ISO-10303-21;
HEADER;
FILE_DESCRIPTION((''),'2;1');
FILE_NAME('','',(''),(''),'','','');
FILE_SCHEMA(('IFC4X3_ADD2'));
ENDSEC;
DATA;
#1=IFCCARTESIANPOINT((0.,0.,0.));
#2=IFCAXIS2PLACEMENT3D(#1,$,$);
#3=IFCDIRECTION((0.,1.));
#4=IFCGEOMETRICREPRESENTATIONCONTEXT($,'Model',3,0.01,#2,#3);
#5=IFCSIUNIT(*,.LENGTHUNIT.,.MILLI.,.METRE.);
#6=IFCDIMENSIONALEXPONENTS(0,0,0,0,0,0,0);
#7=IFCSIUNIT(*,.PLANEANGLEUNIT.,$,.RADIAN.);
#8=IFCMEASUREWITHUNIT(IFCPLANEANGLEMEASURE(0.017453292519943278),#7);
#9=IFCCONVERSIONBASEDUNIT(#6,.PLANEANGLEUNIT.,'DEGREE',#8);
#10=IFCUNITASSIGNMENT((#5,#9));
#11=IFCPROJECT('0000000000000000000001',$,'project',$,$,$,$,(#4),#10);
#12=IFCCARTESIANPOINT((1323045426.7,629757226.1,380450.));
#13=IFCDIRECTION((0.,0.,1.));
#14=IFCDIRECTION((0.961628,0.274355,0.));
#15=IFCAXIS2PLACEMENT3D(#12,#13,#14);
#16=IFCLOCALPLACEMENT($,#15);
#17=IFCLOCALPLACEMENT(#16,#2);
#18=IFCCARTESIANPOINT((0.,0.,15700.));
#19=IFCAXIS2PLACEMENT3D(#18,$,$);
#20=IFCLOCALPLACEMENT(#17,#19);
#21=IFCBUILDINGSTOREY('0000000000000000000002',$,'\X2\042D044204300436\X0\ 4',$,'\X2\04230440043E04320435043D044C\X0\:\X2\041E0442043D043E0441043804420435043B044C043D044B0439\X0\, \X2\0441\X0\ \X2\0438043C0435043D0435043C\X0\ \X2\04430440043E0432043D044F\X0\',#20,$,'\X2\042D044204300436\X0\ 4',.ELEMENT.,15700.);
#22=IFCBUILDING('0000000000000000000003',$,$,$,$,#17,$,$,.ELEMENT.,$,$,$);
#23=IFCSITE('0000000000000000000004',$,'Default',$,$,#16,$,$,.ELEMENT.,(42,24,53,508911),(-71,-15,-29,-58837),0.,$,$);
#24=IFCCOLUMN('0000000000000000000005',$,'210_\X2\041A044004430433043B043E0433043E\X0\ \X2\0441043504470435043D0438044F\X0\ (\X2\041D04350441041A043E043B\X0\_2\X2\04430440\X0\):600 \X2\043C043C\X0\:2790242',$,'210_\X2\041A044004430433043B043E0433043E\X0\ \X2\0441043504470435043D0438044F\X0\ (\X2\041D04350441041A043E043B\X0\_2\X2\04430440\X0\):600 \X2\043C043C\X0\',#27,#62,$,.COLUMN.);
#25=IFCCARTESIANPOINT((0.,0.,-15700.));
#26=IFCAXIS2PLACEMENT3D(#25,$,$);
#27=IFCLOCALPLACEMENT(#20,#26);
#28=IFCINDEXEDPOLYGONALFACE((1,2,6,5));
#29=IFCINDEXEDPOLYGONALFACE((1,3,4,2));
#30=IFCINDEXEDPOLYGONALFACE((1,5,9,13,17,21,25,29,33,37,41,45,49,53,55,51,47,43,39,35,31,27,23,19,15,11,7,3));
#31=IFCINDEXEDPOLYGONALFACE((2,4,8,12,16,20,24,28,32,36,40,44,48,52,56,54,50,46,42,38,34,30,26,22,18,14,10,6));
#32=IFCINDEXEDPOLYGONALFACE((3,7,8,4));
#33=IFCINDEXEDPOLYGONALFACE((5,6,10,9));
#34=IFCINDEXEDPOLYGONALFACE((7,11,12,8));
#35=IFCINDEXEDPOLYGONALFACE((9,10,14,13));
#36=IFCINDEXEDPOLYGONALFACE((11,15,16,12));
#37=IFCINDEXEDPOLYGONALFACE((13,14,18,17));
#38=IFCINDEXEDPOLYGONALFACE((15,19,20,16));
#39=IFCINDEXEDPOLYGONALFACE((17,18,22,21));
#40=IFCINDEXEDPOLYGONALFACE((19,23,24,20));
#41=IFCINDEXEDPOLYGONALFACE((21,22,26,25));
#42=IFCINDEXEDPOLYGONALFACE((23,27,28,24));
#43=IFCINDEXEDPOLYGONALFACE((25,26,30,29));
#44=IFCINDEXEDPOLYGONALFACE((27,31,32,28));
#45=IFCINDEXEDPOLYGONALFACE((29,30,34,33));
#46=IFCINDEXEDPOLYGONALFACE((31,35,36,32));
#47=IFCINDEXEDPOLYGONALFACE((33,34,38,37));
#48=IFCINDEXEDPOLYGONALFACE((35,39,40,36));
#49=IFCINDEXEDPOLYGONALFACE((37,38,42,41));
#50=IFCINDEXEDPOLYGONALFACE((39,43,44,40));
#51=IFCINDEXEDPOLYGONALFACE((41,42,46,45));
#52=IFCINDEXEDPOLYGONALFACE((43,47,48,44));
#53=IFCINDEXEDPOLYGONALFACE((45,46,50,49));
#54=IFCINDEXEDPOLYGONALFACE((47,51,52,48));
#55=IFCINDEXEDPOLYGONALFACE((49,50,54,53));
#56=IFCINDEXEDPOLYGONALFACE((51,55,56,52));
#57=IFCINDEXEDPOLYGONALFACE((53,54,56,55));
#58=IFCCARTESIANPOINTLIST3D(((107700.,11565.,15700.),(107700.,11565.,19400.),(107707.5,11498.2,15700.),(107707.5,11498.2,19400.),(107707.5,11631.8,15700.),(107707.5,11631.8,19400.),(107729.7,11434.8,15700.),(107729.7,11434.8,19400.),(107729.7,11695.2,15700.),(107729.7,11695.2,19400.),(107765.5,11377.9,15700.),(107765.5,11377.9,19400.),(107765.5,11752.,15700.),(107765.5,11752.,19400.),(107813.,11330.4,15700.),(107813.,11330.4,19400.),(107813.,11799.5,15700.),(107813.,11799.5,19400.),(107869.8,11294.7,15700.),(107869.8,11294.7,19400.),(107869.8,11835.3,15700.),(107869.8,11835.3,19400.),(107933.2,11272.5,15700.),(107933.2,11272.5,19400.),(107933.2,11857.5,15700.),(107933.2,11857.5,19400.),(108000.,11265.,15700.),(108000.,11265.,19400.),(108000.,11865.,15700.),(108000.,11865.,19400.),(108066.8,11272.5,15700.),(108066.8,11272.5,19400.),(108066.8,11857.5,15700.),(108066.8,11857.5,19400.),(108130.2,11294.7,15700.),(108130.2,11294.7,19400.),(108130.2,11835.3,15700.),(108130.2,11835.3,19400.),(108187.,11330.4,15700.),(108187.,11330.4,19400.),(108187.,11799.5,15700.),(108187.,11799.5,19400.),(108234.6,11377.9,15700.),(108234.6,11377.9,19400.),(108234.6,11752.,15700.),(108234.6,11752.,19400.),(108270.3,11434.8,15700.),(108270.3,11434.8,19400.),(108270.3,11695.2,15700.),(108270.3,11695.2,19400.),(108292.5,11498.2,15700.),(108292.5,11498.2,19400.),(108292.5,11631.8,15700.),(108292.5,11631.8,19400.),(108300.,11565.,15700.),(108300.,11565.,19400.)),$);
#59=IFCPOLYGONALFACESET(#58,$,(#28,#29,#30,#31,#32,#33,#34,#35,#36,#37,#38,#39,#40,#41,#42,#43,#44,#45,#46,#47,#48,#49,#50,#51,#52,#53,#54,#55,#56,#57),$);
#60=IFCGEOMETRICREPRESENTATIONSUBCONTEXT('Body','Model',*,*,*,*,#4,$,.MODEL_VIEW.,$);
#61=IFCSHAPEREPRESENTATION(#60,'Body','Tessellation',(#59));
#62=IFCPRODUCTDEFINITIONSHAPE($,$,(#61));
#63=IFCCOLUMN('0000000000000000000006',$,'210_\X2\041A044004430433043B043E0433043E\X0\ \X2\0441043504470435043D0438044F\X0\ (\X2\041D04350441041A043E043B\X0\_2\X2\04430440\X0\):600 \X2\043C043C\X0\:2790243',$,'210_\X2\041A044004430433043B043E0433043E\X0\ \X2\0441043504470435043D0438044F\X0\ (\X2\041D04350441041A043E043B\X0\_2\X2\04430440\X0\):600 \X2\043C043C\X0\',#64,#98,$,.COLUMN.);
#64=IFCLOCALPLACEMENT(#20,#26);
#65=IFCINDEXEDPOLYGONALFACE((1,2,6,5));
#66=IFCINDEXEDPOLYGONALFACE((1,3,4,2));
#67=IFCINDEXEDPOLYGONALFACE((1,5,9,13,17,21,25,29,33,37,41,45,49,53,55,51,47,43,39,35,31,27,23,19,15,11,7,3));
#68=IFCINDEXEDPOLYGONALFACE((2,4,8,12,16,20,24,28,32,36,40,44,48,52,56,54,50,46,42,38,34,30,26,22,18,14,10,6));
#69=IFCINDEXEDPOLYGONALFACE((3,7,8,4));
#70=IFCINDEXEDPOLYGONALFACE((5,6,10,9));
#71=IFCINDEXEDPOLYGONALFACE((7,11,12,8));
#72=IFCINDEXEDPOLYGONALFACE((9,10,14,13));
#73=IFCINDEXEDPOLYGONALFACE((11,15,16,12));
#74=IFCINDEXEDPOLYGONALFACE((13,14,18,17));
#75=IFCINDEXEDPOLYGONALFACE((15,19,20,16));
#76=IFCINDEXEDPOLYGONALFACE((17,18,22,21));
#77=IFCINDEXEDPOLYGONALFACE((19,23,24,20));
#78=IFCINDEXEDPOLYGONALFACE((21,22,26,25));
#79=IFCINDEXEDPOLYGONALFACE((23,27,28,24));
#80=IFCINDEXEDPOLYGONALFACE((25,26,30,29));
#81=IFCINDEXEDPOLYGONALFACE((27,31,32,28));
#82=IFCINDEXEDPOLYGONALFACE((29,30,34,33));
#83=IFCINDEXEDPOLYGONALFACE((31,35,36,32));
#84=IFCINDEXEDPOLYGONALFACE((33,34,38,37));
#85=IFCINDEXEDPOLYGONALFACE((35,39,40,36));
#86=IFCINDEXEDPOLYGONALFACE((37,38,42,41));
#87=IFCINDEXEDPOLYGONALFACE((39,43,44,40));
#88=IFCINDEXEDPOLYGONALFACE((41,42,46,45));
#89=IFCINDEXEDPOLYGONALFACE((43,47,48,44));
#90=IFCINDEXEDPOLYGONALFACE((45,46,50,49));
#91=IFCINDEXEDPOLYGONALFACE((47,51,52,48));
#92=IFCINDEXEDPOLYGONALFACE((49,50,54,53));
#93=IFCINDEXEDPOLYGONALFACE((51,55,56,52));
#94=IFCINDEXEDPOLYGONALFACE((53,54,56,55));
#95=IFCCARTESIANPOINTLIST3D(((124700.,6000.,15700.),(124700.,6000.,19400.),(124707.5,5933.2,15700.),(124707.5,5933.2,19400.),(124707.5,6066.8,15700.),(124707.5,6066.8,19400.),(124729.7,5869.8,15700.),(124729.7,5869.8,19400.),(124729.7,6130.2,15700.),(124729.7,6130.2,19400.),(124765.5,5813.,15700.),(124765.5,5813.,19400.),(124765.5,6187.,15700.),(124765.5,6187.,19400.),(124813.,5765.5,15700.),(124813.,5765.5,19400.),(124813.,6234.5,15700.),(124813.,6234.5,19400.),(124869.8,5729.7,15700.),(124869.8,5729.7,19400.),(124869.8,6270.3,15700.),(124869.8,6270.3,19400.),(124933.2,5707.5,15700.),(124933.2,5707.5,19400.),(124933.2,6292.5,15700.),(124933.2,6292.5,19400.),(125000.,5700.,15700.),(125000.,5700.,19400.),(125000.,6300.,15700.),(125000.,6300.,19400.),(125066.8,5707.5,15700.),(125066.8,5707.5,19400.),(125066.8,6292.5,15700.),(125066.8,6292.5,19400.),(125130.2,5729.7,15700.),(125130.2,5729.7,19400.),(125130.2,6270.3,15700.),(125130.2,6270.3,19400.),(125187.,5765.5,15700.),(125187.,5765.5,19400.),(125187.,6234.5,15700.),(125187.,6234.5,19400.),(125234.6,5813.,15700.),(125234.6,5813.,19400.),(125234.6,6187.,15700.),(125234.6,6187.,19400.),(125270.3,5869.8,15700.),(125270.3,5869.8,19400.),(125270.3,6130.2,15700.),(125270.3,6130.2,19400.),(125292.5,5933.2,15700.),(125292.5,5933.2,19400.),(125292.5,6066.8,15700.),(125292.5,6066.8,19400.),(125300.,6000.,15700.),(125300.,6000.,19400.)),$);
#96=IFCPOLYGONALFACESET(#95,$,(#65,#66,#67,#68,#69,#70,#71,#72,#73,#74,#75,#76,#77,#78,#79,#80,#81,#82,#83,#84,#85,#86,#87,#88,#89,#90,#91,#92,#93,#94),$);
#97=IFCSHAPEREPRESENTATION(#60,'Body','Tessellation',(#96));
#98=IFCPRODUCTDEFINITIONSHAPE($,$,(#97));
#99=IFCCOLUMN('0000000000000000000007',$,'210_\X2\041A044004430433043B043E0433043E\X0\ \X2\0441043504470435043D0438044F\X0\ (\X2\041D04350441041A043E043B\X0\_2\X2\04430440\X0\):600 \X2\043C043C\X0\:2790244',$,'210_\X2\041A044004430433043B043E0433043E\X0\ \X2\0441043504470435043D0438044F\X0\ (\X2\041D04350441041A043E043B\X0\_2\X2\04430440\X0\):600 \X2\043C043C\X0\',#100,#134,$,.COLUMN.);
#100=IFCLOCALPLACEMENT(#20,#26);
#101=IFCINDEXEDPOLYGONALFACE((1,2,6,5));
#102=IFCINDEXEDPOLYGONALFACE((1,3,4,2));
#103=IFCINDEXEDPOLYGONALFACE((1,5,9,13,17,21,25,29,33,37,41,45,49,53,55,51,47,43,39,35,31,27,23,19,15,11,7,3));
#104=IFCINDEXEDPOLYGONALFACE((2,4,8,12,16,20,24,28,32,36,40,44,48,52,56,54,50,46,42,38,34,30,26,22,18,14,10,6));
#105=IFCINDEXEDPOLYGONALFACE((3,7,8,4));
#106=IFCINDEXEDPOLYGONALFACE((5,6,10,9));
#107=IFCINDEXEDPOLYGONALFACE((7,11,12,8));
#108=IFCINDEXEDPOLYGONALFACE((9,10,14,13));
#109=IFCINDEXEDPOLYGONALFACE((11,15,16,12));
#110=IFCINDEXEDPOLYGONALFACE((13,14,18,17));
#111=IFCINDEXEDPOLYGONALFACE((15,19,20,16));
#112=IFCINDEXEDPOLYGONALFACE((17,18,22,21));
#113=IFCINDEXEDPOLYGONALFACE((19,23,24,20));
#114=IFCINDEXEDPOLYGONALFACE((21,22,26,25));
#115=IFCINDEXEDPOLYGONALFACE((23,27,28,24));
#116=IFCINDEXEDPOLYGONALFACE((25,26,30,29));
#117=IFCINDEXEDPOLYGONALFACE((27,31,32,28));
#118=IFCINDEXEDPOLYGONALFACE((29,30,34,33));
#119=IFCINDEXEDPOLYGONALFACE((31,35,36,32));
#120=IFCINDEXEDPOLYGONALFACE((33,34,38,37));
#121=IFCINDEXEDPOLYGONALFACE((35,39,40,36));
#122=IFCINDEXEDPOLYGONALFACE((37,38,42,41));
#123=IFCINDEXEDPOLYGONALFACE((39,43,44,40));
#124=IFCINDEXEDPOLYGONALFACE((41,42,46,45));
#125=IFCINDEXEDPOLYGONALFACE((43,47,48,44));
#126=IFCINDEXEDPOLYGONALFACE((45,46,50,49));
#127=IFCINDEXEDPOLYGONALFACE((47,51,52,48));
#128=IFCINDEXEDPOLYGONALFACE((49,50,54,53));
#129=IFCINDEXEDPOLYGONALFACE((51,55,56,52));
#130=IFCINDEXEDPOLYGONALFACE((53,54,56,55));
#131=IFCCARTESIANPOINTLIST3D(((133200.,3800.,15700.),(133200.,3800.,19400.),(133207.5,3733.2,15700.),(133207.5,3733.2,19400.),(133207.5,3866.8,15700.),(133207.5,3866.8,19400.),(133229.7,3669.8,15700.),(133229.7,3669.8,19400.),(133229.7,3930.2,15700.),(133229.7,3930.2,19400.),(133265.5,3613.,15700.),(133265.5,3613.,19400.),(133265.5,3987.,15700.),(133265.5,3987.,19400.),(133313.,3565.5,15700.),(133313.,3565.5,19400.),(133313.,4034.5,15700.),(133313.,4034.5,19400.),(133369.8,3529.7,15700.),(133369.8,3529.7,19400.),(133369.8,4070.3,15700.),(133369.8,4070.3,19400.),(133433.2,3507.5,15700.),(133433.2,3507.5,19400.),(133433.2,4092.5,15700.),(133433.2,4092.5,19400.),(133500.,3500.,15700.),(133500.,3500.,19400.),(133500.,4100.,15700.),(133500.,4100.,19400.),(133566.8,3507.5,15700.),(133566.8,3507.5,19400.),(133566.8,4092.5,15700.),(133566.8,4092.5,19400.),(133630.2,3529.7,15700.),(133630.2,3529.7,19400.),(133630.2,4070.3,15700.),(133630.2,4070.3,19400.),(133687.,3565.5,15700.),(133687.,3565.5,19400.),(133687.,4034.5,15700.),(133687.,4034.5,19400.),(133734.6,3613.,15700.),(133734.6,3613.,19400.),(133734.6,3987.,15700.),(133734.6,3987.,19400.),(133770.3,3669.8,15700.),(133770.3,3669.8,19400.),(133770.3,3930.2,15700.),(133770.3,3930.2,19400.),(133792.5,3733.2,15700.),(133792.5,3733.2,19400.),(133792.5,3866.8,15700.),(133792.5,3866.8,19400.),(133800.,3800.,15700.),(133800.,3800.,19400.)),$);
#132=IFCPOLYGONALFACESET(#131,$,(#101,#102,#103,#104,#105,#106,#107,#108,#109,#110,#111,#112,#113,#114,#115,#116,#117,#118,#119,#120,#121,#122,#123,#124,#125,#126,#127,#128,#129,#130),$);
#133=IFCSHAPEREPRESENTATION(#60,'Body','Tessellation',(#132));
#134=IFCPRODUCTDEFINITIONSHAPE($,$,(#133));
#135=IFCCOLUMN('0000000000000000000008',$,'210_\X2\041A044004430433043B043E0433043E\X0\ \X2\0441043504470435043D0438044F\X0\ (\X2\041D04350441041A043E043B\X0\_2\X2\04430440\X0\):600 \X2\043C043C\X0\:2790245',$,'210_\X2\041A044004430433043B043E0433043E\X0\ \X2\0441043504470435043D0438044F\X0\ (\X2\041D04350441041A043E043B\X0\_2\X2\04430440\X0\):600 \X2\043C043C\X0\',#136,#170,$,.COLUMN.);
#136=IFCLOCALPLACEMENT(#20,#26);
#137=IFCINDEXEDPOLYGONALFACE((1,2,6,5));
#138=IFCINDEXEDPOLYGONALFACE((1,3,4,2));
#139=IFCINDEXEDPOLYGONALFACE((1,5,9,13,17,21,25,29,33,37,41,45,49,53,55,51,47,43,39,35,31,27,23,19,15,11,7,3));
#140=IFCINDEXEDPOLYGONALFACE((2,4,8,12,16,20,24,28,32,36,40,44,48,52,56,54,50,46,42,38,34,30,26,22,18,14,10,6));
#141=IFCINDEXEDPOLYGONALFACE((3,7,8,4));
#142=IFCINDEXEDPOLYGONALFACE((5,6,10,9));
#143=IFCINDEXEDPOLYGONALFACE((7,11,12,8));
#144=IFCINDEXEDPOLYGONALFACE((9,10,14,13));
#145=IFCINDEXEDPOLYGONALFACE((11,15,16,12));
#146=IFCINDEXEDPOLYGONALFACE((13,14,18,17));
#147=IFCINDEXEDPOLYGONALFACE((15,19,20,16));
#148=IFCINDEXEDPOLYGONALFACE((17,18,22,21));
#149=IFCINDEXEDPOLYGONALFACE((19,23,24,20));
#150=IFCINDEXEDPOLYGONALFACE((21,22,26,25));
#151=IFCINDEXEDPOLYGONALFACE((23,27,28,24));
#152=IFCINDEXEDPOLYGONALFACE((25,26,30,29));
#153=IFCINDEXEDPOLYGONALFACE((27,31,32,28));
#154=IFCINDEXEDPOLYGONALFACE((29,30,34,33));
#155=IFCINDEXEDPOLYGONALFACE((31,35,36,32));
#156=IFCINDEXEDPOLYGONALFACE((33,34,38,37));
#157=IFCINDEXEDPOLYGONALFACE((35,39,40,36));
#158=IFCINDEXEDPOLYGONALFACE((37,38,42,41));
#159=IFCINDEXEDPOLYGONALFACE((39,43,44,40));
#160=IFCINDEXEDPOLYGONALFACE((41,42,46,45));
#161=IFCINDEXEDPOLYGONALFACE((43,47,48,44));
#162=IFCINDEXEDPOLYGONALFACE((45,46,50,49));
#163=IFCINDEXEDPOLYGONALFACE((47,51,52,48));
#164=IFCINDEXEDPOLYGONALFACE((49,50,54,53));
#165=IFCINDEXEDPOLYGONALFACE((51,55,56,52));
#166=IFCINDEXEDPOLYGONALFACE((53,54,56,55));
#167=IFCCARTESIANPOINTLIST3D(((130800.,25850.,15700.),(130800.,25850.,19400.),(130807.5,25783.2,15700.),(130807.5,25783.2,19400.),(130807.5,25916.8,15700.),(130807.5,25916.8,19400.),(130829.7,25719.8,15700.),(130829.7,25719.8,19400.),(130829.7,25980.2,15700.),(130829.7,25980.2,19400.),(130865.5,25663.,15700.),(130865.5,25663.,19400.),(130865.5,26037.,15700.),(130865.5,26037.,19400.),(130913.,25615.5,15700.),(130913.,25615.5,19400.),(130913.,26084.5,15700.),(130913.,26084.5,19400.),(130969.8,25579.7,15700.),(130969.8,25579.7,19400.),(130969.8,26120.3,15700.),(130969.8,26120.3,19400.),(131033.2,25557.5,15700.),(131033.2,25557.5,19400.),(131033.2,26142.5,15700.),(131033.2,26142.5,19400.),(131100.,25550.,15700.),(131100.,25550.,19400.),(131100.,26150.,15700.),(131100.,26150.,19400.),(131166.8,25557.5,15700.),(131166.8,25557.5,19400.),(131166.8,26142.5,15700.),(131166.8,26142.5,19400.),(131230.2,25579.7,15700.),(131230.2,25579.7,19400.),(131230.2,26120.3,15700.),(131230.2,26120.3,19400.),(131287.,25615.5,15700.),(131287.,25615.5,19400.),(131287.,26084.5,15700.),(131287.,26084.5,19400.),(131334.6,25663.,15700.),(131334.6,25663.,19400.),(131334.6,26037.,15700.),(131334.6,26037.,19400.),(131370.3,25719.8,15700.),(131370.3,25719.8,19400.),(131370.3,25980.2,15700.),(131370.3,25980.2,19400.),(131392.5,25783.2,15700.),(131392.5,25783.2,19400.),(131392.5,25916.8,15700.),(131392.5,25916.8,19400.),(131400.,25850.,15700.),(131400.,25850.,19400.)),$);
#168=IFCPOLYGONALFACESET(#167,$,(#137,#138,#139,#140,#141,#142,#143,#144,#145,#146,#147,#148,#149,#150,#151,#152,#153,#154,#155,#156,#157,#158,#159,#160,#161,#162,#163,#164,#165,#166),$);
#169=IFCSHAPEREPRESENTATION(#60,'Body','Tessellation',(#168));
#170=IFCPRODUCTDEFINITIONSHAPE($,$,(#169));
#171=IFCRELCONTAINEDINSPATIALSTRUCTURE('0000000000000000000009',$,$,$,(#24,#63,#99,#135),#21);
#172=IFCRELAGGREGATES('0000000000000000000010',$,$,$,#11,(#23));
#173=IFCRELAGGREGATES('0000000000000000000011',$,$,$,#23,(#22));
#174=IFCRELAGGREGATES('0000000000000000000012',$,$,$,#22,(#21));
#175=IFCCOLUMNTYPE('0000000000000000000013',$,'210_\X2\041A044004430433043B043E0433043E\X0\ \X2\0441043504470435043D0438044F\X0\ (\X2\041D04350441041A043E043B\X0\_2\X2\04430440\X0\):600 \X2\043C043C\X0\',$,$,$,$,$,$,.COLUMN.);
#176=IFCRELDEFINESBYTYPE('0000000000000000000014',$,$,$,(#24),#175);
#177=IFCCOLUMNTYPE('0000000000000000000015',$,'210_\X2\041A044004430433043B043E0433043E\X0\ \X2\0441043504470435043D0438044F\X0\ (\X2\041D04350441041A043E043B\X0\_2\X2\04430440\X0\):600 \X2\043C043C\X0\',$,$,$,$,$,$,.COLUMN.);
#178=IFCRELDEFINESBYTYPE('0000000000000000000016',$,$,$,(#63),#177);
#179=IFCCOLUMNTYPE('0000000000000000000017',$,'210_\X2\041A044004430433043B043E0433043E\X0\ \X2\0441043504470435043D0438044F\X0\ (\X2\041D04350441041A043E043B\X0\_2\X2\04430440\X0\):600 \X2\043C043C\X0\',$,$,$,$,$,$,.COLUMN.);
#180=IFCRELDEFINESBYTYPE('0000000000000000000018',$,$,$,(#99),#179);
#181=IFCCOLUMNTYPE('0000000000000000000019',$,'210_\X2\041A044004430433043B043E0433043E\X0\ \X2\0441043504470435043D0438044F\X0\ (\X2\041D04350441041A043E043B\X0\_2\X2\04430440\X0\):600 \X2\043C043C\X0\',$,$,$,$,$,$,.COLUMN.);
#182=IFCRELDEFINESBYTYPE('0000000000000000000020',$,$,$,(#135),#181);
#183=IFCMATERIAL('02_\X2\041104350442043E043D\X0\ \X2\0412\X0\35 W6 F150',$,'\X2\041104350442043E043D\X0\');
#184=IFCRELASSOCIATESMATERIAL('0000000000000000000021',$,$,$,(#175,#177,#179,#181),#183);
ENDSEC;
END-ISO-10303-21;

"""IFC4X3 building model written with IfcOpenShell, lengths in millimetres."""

from ifc_helpers import new_model, entity, si_unit, converted_unit, direction, frame, frame_2d, origin, origin_2d_with_axis, place, context, subcontext, project, spatial, circle, extrude, source, transform, mapped, material, material_profile, profile_set, type_object, type_shapes, element, save


model = new_model("IFC4X3")

# Units and contexts
model_context = context("Model", 3, precision=0.01, world=origin(), true_north=direction((0.0, 1.0)))
body_context = subcontext(model_context, "Body", "Model", "MODEL_VIEW")
ifc_project = project(units=[si_unit("LENGTHUNIT", "METRE", prefix="MILLI"), converted_unit("PLANEANGLEUNIT", "DEGREE", entity("IfcPlaneAngleMeasure", 0.017453292519943278), si_unit("PLANEANGLEUNIT", "RADIAN"), dimensions=[0, 0, 0, 0, 0, 0, 0])], contexts=[model_context])

# Site, building, storey
site_placement = place(None, frame((1323045426.7, 629757226.1, 380450.0), z_axis=(0.0, 0.0, 1.0), x_axis=(0.961628, 0.274355, 0.0)))
site = spatial("IfcSite", under=ifc_project, at=site_placement, Name="Default", CompositionType="ELEMENT", RefLatitude=(42, 24, 53, 508911), RefLongitude=(-71, -15, -29, -58837), RefElevation=0.0)
building_placement = place(site_placement, origin())
building = spatial("IfcBuilding", under=site, at=building_placement, CompositionType="ELEMENT")
storey_placement = place(building_placement, frame((0.0, 0.0, 15700.0)))
storey = spatial("IfcBuildingStorey", under=building, at=storey_placement, Name="Этаж 4", ObjectType="Уровень:Относительный, с именем уровня", LongName="Этаж 4", CompositionType="ELEMENT", Elevation=15700.0)

# Columns
ifc_material = material(Name="02_Бетон В35 W6 F150", Category="Бетон")
ifc_material_profile = material_profile(ifc_material, circle(Radius=300.0, at=origin_2d_with_axis()), Name="600 мм")
ifc_profile_set = profile_set([ifc_material_profile], Name="600 мм")
column_type_1 = type_object("IfcColumnType", Name="210_Круглого сечения (НесКол_2ур):600 мм", PredefinedType="COLUMN", material=ifc_profile_set)
shared_shape_1 = source(origin(), body_context, "Body", "SweptSolid", [
    extrude(circle(Radius=300.0, at=origin_2d_with_axis()), frame((108000.0, 11565.0, 15700.0)), (0.0, 0.0, 1.0), 3700.0),
])
type_shapes(column_type_1, [shared_shape_1])
column_1_placement = place(storey_placement, frame((0.0, 0.0, -15700.0)))
element("IfcColumn", 1, at=column_1_placement, inside=storey, type_object=column_type_1, Name="210_Круглого сечения (НесКол_2ур):600 мм:2790242", ObjectType="210_Круглого сечения (НесКол_2ур):600 мм", PredefinedType="COLUMN", context=body_context, shape_type="MappedRepresentation", body=[
    mapped(shared_shape_1, transform((0.0, 0.0, 0.0), scale=1.0)),
])
column_type_2 = type_object("IfcColumnType", Name="210_Круглого сечения (НесКол_2ур):600 мм", PredefinedType="COLUMN", material=ifc_profile_set)
shared_shape_2 = source(origin(), body_context, "Body", "SweptSolid", [
    extrude(circle(Radius=300.0, at=frame_2d((0.0, 0.0), x_axis=(1.0, 0.0))), frame((125000.0, 6000.0, 15700.0)), (0.0, 0.0, 1.0), 3700.0),
])
type_shapes(column_type_2, [shared_shape_2])
column_2_placement = place(storey_placement, frame((0.0, 0.0, -15700.0)))
element("IfcColumn", 2, at=column_2_placement, inside=storey, type_object=column_type_2, Name="210_Круглого сечения (НесКол_2ур):600 мм:2790243", ObjectType="210_Круглого сечения (НесКол_2ур):600 мм", PredefinedType="COLUMN", context=body_context, shape_type="MappedRepresentation", body=[
    mapped(shared_shape_2, transform((0.0, 0.0, 0.0), scale=1.0)),
])
column_type_3 = type_object("IfcColumnType", Name="210_Круглого сечения (НесКол_2ур):600 мм", PredefinedType="COLUMN", material=ifc_profile_set)
shared_shape_3 = source(origin(), body_context, "Body", "SweptSolid", [
    extrude(circle(Radius=300.0, at=frame_2d((0.0, 0.0), x_axis=(1.0, 0.0))), frame((133500.0, 3800.0, 15700.0)), (0.0, 0.0, 1.0), 3700.0),
])
type_shapes(column_type_3, [shared_shape_3])
column_3_placement = place(storey_placement, frame((0.0, 0.0, -15700.0)))
element("IfcColumn", 3, at=column_3_placement, inside=storey, type_object=column_type_3, Name="210_Круглого сечения (НесКол_2ур):600 мм:2790244", ObjectType="210_Круглого сечения (НесКол_2ур):600 мм", PredefinedType="COLUMN", context=body_context, shape_type="MappedRepresentation", body=[
    mapped(shared_shape_3, transform((0.0, 0.0, 0.0), scale=1.0)),
])
column_type_4 = type_object("IfcColumnType", Name="210_Круглого сечения (НесКол_2ур):600 мм", PredefinedType="COLUMN", material=ifc_profile_set)
shared_shape_4 = source(origin(), body_context, "Body", "SweptSolid", [
    extrude(circle(Radius=300.0, at=origin_2d_with_axis()), frame((131100.0, 25850.0, 15700.0)), (0.0, 0.0, 1.0), 3700.0),
])
type_shapes(column_type_4, [shared_shape_4])
column_4_placement = place(storey_placement, frame((0.0, 0.0, -15700.0)))
element("IfcColumn", 4, at=column_4_placement, inside=storey, type_object=column_type_4, Name="210_Круглого сечения (НесКол_2ур):600 мм:2790245", ObjectType="210_Круглого сечения (НесКол_2ур):600 мм", PredefinedType="COLUMN", context=body_context, shape_type="MappedRepresentation", body=[
    mapped(shared_shape_4, transform((0.0, 0.0, 0.0), scale=1.0)),
])

save(model, "model.ifc")
